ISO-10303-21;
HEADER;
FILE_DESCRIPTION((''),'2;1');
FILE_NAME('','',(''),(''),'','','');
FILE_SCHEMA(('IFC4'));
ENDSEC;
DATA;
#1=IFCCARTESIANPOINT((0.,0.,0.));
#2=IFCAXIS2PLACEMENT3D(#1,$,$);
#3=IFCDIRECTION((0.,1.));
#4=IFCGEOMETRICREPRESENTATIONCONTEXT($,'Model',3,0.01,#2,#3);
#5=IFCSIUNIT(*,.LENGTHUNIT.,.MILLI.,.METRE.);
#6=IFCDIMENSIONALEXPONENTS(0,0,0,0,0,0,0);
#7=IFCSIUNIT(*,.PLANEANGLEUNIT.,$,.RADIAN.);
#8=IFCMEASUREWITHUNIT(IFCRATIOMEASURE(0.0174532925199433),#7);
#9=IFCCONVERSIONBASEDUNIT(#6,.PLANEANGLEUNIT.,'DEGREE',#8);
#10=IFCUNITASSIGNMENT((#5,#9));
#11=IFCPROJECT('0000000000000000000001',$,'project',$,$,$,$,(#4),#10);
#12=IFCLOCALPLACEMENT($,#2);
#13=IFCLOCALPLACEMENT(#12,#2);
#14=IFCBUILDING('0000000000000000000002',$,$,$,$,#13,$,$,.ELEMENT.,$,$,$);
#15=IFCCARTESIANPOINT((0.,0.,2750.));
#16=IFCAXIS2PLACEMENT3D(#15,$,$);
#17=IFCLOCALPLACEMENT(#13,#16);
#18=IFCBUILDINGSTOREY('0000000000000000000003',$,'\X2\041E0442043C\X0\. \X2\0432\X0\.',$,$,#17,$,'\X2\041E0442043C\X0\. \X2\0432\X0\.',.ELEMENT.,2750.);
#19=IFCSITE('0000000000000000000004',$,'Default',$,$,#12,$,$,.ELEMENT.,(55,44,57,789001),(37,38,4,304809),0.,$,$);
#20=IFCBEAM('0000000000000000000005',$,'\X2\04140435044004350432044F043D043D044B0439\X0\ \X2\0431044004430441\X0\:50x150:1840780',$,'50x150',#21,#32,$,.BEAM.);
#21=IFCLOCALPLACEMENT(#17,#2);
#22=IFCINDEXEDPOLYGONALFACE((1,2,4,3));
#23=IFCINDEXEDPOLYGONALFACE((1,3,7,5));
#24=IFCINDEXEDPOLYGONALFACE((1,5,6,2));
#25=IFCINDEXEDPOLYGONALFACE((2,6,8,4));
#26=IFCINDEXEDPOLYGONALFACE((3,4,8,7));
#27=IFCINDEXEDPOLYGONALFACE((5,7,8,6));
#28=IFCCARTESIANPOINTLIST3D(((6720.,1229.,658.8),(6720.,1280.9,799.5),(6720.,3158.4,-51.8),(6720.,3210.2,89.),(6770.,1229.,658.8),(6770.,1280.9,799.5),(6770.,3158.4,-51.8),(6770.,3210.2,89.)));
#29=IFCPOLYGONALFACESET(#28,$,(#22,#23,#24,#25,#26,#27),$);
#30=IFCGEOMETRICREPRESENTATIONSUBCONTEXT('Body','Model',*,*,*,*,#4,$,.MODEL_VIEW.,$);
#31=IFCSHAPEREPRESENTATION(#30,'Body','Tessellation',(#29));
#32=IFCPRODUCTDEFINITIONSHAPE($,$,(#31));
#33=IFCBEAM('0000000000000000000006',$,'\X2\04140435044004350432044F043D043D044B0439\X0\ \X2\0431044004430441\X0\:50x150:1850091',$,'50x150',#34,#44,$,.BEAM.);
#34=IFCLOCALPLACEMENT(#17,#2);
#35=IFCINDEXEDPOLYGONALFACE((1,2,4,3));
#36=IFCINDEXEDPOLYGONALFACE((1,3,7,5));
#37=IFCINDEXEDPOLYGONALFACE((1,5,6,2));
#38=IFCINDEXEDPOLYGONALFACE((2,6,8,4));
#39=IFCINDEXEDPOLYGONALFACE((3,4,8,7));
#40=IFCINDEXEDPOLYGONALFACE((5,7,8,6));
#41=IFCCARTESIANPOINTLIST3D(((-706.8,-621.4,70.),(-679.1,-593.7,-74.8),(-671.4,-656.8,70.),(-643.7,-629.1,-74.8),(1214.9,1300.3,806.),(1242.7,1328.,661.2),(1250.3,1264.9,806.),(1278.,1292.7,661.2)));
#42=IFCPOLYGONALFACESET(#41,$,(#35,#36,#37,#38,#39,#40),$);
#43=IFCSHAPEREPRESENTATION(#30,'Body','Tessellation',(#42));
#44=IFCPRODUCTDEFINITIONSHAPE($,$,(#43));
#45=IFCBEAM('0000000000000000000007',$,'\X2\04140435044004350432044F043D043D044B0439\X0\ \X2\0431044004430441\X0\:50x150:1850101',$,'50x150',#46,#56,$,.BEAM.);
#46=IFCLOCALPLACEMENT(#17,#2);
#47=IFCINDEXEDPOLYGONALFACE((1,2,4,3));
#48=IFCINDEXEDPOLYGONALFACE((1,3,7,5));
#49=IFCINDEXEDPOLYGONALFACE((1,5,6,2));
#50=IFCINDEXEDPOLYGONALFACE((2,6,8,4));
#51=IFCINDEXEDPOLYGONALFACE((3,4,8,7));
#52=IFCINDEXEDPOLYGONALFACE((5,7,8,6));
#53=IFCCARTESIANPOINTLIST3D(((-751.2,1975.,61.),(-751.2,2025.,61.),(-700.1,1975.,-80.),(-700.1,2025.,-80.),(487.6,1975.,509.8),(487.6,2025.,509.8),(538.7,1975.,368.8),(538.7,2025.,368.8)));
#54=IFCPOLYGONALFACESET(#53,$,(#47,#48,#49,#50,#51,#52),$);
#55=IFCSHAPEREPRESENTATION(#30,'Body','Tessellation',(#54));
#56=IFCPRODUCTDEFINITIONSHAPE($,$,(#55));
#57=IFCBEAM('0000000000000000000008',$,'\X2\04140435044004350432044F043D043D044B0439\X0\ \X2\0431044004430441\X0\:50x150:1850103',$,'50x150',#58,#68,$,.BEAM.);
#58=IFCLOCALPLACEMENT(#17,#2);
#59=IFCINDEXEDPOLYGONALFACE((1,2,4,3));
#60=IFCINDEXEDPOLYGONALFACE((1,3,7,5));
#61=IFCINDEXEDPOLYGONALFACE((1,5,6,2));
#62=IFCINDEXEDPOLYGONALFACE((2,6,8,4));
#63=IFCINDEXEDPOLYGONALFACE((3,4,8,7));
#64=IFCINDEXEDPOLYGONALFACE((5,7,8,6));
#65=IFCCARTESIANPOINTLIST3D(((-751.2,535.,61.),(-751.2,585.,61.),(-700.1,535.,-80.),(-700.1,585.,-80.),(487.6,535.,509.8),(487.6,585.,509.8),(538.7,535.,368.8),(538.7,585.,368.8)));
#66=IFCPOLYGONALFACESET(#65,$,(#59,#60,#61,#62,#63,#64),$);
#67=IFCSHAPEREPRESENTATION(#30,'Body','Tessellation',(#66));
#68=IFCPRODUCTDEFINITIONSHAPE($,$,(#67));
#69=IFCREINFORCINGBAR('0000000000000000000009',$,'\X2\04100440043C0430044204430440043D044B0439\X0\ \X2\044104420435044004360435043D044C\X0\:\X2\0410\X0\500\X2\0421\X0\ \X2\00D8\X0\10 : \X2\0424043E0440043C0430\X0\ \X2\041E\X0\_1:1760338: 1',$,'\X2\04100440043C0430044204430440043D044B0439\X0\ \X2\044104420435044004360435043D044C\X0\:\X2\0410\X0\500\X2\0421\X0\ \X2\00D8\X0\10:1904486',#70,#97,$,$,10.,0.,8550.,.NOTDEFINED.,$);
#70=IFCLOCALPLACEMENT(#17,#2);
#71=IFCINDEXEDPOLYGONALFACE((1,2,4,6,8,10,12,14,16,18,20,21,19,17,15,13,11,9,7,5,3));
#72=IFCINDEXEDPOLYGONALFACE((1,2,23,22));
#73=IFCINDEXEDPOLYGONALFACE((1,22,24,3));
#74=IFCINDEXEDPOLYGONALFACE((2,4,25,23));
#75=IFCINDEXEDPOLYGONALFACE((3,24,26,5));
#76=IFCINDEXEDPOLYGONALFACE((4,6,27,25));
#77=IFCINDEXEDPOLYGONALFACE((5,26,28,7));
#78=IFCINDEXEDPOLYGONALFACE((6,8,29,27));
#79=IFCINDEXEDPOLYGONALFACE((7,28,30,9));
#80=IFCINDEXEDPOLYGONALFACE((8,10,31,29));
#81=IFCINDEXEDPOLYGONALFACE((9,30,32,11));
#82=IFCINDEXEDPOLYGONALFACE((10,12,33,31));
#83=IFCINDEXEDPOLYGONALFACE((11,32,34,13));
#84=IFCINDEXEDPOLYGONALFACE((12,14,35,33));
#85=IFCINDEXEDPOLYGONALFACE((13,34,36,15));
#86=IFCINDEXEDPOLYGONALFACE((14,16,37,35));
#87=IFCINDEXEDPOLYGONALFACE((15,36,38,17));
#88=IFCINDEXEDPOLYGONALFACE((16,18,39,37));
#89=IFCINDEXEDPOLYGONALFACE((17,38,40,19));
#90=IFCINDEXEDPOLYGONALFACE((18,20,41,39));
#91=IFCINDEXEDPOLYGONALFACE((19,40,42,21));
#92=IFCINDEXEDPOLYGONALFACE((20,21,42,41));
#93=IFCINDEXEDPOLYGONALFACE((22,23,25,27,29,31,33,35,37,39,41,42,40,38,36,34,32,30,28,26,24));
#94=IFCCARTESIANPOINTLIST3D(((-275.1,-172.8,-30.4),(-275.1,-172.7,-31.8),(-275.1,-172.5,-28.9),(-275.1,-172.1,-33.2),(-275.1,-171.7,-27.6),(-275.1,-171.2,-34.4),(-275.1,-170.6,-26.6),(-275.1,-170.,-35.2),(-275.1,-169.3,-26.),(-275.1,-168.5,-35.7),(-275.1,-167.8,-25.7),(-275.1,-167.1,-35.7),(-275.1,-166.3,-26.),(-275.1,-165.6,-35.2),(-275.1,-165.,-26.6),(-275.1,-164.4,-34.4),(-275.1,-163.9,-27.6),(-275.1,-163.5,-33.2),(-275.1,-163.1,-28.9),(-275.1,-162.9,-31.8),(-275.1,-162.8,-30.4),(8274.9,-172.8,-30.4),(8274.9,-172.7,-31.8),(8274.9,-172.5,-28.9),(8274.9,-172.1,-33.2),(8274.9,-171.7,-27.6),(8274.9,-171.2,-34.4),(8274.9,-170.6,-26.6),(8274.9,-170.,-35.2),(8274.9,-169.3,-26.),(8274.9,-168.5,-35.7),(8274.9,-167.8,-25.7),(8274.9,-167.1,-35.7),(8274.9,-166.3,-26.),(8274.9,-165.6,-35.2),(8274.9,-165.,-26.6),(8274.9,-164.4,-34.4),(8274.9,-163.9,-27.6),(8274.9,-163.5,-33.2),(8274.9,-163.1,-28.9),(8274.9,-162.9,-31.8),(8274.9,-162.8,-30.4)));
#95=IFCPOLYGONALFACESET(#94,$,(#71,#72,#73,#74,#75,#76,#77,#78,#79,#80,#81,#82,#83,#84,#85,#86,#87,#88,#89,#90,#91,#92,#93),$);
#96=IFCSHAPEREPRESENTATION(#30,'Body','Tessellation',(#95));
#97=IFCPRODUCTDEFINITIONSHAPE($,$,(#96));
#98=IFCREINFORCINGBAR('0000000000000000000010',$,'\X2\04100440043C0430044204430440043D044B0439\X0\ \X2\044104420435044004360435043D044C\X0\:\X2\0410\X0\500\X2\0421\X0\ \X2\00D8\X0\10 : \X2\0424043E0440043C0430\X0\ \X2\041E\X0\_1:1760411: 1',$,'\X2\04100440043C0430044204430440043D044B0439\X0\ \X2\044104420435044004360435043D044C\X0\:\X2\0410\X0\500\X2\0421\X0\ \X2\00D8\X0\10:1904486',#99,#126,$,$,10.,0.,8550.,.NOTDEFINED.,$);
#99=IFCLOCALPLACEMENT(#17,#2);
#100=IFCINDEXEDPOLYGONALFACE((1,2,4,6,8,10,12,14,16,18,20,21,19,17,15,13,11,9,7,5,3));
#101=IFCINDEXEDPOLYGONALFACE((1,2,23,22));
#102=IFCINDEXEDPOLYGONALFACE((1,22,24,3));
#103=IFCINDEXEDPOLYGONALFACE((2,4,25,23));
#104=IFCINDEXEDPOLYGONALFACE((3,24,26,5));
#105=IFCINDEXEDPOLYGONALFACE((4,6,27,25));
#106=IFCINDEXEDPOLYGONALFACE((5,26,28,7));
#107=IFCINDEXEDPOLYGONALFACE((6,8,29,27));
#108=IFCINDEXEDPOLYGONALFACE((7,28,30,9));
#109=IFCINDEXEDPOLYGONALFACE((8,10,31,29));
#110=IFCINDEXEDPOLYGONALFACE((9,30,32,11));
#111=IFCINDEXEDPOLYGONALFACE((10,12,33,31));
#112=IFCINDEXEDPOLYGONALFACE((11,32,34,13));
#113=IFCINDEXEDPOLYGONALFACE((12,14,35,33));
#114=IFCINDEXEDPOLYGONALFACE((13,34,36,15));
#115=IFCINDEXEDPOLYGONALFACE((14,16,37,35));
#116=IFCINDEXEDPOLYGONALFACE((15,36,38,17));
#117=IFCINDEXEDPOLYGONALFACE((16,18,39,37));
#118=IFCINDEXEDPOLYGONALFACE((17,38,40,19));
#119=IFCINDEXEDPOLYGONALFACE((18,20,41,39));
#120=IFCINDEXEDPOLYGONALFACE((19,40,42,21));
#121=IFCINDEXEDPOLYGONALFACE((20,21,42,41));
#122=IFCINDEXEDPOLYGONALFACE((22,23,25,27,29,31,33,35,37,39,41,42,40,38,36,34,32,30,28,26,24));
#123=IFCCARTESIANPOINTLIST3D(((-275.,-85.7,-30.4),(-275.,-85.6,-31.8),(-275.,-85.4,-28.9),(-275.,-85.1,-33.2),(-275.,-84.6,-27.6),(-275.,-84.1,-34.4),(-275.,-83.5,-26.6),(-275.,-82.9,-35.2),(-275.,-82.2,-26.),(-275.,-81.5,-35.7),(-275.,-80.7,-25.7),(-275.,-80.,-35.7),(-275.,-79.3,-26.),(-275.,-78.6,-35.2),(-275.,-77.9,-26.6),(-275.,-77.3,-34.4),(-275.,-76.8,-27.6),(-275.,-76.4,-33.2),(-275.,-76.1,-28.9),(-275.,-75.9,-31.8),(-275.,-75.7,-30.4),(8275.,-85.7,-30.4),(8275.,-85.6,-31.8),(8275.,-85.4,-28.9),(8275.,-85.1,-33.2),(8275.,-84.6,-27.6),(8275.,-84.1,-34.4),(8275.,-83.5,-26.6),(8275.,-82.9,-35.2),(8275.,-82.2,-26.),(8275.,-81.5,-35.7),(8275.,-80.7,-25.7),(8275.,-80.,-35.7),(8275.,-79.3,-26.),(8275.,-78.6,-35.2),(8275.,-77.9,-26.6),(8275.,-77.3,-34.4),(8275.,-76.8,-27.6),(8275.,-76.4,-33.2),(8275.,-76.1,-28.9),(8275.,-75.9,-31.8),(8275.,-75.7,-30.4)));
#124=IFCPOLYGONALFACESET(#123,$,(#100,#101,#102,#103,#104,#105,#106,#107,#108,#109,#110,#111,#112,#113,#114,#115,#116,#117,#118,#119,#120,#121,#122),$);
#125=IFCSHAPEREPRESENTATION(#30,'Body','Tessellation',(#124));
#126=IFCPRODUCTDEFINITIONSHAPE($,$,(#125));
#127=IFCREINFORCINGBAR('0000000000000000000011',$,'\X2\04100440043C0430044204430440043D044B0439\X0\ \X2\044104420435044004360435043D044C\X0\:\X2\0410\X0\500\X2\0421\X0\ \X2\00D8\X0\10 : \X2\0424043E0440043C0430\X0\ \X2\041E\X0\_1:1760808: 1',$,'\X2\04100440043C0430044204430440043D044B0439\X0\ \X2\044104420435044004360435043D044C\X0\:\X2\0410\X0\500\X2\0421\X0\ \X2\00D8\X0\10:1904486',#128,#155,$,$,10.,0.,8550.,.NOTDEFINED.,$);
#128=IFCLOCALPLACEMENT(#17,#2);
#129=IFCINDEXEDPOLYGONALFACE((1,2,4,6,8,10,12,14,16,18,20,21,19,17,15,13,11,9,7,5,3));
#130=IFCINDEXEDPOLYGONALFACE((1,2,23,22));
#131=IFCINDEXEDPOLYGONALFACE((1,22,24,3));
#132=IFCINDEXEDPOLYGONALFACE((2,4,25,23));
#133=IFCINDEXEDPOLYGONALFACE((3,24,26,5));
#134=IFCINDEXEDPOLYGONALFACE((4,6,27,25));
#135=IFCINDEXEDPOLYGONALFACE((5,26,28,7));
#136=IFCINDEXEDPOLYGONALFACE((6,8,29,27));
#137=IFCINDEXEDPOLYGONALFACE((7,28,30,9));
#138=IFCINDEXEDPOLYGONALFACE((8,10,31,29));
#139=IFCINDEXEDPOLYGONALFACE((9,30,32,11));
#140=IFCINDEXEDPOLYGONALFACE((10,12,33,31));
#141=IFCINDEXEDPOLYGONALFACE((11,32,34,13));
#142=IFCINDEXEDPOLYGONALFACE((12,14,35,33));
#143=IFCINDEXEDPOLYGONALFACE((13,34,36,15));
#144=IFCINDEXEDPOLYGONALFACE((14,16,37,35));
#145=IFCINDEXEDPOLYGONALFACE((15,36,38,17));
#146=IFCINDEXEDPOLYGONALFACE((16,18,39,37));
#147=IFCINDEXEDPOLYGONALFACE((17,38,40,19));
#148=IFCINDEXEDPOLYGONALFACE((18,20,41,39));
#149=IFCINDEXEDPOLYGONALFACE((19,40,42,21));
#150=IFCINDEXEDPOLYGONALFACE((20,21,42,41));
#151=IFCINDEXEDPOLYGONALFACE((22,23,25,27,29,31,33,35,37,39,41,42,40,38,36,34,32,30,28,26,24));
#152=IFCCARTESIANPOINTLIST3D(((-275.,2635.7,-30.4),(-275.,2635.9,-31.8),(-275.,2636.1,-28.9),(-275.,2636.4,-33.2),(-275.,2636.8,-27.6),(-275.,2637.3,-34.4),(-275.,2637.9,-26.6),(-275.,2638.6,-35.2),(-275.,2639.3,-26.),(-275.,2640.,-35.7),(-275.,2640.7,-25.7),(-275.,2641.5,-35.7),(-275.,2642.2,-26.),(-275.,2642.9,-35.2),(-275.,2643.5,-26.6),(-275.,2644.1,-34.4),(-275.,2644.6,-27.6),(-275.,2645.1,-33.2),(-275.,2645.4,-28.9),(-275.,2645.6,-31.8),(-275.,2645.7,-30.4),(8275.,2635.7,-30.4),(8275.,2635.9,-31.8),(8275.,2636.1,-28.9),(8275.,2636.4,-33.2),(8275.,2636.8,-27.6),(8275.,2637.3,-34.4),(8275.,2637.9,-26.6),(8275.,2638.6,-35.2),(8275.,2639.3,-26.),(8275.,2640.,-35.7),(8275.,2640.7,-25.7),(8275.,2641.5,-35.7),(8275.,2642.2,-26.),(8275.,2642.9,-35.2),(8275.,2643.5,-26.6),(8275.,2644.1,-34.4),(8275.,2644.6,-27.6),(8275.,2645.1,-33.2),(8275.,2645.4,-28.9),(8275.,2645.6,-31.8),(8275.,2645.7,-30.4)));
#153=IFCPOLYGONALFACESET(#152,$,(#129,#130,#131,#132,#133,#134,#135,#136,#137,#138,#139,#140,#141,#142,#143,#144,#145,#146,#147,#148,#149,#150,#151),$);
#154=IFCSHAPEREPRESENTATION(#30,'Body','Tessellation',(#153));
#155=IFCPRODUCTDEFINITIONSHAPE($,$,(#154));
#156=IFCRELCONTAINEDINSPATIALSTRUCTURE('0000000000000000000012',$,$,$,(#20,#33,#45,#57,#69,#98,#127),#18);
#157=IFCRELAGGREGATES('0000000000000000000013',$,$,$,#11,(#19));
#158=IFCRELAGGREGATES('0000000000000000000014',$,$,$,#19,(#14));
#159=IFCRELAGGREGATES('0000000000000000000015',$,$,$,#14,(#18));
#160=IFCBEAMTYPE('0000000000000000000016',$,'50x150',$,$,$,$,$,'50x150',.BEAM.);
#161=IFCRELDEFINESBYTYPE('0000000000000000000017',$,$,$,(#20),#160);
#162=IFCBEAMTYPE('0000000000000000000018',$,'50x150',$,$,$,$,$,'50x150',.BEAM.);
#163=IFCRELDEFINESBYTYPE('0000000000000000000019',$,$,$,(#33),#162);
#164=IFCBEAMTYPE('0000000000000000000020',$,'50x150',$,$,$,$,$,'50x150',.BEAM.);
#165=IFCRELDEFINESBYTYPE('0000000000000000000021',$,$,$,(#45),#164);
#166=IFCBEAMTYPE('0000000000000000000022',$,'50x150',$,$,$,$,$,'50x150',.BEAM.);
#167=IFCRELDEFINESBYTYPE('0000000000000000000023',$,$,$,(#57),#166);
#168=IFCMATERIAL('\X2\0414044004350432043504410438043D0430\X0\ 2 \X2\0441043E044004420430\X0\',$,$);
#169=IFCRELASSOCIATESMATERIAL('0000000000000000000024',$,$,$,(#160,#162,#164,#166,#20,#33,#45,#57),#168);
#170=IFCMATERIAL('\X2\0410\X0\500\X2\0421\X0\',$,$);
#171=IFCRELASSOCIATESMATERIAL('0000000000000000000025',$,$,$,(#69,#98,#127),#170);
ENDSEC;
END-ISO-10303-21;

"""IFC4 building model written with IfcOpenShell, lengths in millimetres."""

from ifc_helpers import new_model, entity, si_unit, converted_unit, direction, frame, frame_2d, origin, place, context, subcontext, project, spatial, rectangle, extrude, source, transform, mapped, material, material_profile, profile_set, profile_usage, type_object, type_shapes, element, save


model = new_model("IFC4")

# Units and contexts
model_context = context("Model", 3, precision=0.01, world=origin(), true_north=direction((0.0, 1.0)))
body_context = subcontext(model_context, "Body", "Model", "MODEL_VIEW")
ifc_project = project(units=[si_unit("LENGTHUNIT", "METRE", prefix="MILLI"), converted_unit("PLANEANGLEUNIT", "DEGREE", entity("IfcRatioMeasure", 0.0174532925199433), si_unit("PLANEANGLEUNIT", "RADIAN"), dimensions=[0, 0, 0, 0, 0, 0, 0])], contexts=[model_context])

# Site, building, storey
site_placement = place(None, origin())
site = spatial("IfcSite", under=ifc_project, at=site_placement, Name="Default", CompositionType="ELEMENT", RefLatitude=(55, 44, 57, 789001), RefLongitude=(37, 38, 4, 304809), RefElevation=0.0)
building_placement = place(site_placement, origin())
building = spatial("IfcBuilding", under=site, at=building_placement, CompositionType="ELEMENT")
storey_placement = place(building_placement, frame((0.0, 0.0, 2750.0)))
storey = spatial("IfcBuildingStorey", under=building, at=storey_placement, Name="Отм. в.", LongName="Отм. в.", CompositionType="ELEMENT", Elevation=2750.0)

# Beams
ifc_material_1 = material(Name="Древесина 2 сорта")
ifc_material_profile_1 = material_profile(ifc_material_1, rectangle(XDim=150.0, YDim=50.0, at=frame_2d((0.0, 0.0), x_axis=(1.0, 0.0))))
ifc_profile_set_1 = profile_set([ifc_material_profile_1], Name="50x150")
ifc_profile_usage_1 = profile_usage(ifc_profile_set_1)
beam_type_1 = type_object("IfcBeamType", Name="50x150", ElementType="50x150", PredefinedType="BEAM", material=ifc_profile_set_1)
shared_shape_1 = source(origin(), body_context, "Body", "SweptSolid", [
    extrude(rectangle(XDim=150.0, YDim=50.0, at=frame_2d((0.0, 0.0), x_axis=(1.0, 0.0))), frame((6745.0, 3184.3, 2768.6), z_axis=(0.0, -0.938384, 0.345594), x_axis=(0.0, -0.345594, -0.938384)), (0.0, 0.0, 1.0), 2056.0),
])
type_shapes(beam_type_1, [shared_shape_1])
beam_1_placement = place(storey_placement, frame((0.0, 0.0, -2750.0)))
element("IfcBeam", 1, at=beam_1_placement, inside=storey, type_object=beam_type_1, material=ifc_profile_usage_1, Name="Деревянный брус:50x150:1840780", ObjectType="50x150", PredefinedType="BEAM", context=body_context, shape_type="MappedRepresentation", body=[
    mapped(shared_shape_1, transform((0.0, 0.0, 0.0), scale=1.0)),
])
ifc_profile_usage_2 = profile_usage(ifc_profile_set_1)
beam_type_2 = type_object("IfcBeamType", Name="50x150", ElementType="50x150", PredefinedType="BEAM", material=ifc_profile_set_1)
shared_shape_2 = source(origin(), body_context, "Body", "SweptSolid", [
    extrude(rectangle(XDim=150.0, YDim=50.0, at=frame_2d((0.0, 0.0), x_axis=(0.0, 1.0))), frame((1246.5, 1296.5, 3483.6), z_axis=(-0.682523, -0.682523, -0.261392), x_axis=(-0.707107, 0.707107, 0.0)), (0.0, 0.0, 1.0), 2815.6),
])
type_shapes(beam_type_2, [shared_shape_2])
beam_2_placement = place(storey_placement, frame((0.0, 0.0, -2750.0)))
element("IfcBeam", 2, at=beam_2_placement, inside=storey, type_object=beam_type_2, material=ifc_profile_usage_2, Name="Деревянный брус:50x150:1850091", ObjectType="50x150", PredefinedType="BEAM", context=body_context, shape_type="MappedRepresentation", body=[
    mapped(shared_shape_2, transform((0.0, 0.0, 0.0), scale=1.0)),
])
ifc_profile_usage_3 = profile_usage(ifc_profile_set_1)
beam_type_3 = type_object("IfcBeamType", Name="50x150", ElementType="50x150", PredefinedType="BEAM", material=ifc_profile_set_1)
shared_shape_3 = source(origin(), body_context, "Body", "SweptSolid", [
    extrude(rectangle(XDim=150.0, YDim=50.0, at=frame_2d((0.0, 0.0), x_axis=(1.0, 0.0))), frame((25.5, 25.0, 70.5), z_axis=(0.940198, 0.0, 0.340629), x_axis=(0.340629, 0.0, -0.940198)), (0.0, 0.0, 1.0), 1317.6),
])
type_shapes(beam_type_3, [shared_shape_3])
beam_3_placement = place(storey_placement, frame((-751.2, 1975.0, -80.0)))
element("IfcBeam", 3, at=beam_3_placement, inside=storey, type_object=beam_type_3, material=ifc_profile_usage_3, Name="Деревянный брус:50x150:1850101", ObjectType="50x150", PredefinedType="BEAM", context=body_context, shape_type="MappedRepresentation", body=[
    mapped(shared_shape_3, transform((0.0, 0.0, 0.0), scale=1.0)),
])
ifc_profile_usage_4 = profile_usage(ifc_profile_set_1)
beam_type_4 = type_object("IfcBeamType", Name="50x150", ElementType="50x150", PredefinedType="BEAM", material=ifc_profile_set_1)
shared_shape_4 = source(origin(), body_context, "Body", "SweptSolid", [
    extrude(rectangle(XDim=150.0, YDim=50.0, at=frame_2d((0.0, 0.0), x_axis=(0.0, 1.0))), frame((25.5, 25.0, 70.5), z_axis=(0.940198, 0.0, 0.340629), x_axis=(0.0, -1.0, 0.0)), (0.0, 0.0, 1.0), 1317.6),
])
type_shapes(beam_type_4, [shared_shape_4])
beam_4_placement = place(storey_placement, frame((-751.2, 535.0, -80.0)))
element("IfcBeam", 4, at=beam_4_placement, inside=storey, type_object=beam_type_4, material=ifc_profile_usage_4, Name="Деревянный брус:50x150:1850103", ObjectType="50x150", PredefinedType="BEAM", context=body_context, shape_type="MappedRepresentation", body=[
    mapped(shared_shape_4, transform((0.0, 0.0, 0.0), scale=1.0)),
])

# Reinforcing bars
ifc_material_2 = material(Name="А500С")
reinforcing_bar_1_placement = place(storey_placement, origin())
element("IfcReinforcingBar", 5, at=reinforcing_bar_1_placement, inside=storey, material=ifc_material_2, Name="Арматурный стержень:А500С Ø10 : Форма О_1:1760338: 1", ObjectType="Арматурный стержень:А500С Ø10:1904486", BarLength=8550.0, CrossSectionArea=0.0, NominalDiameter=10.0, PredefinedType="NOTDEFINED", context=body_context, shape_type="AdvancedSweptSolid", body=[
    entity("IfcSweptDiskSolid", entity("IfcCompositeCurve", [entity("IfcCompositeCurveSegment", "CONTINUOUS", True, entity("IfcPolyline", [entity("IfcCartesianPoint", [-275.1, -167.8, -30.7]), entity("IfcCartesianPoint", [8274.9, -167.8, -30.7])]))], False), 5.0, None, 0.0, 1.0),
])
reinforcing_bar_2_placement = place(storey_placement, origin())
element("IfcReinforcingBar", 6, at=reinforcing_bar_2_placement, inside=storey, material=ifc_material_2, Name="Арматурный стержень:А500С Ø10 : Форма О_1:1760411: 1", ObjectType="Арматурный стержень:А500С Ø10:1904486", BarLength=8550.0, CrossSectionArea=0.0, NominalDiameter=10.0, PredefinedType="NOTDEFINED", context=body_context, shape_type="AdvancedSweptSolid", body=[
    entity("IfcSweptDiskSolid", entity("IfcCompositeCurve", [entity("IfcCompositeCurveSegment", "CONTINUOUS", True, entity("IfcPolyline", [entity("IfcCartesianPoint", [-275.0, -80.7, -30.7]), entity("IfcCartesianPoint", [8275.0, -80.7, -30.7])]))], False), 5.0, None, 0.0, 1.0),
])
reinforcing_bar_3_placement = place(storey_placement, origin())
element("IfcReinforcingBar", 7, at=reinforcing_bar_3_placement, inside=storey, material=ifc_material_2, Name="Арматурный стержень:А500С Ø10 : Форма О_1:1760808: 1", ObjectType="Арматурный стержень:А500С Ø10:1904486", BarLength=8550.0, CrossSectionArea=0.0, NominalDiameter=10.0, PredefinedType="NOTDEFINED", context=body_context, shape_type="AdvancedSweptSolid", body=[
    entity("IfcSweptDiskSolid", entity("IfcCompositeCurve", [entity("IfcCompositeCurveSegment", "CONTINUOUS", True, entity("IfcPolyline", [entity("IfcCartesianPoint", [-275.0, 2640.7, -30.7]), entity("IfcCartesianPoint", [8275.0, 2640.7, -30.7])]))], False), 5.0, None, 0.0, 1.0),
])

save(model, "model.ifc")
